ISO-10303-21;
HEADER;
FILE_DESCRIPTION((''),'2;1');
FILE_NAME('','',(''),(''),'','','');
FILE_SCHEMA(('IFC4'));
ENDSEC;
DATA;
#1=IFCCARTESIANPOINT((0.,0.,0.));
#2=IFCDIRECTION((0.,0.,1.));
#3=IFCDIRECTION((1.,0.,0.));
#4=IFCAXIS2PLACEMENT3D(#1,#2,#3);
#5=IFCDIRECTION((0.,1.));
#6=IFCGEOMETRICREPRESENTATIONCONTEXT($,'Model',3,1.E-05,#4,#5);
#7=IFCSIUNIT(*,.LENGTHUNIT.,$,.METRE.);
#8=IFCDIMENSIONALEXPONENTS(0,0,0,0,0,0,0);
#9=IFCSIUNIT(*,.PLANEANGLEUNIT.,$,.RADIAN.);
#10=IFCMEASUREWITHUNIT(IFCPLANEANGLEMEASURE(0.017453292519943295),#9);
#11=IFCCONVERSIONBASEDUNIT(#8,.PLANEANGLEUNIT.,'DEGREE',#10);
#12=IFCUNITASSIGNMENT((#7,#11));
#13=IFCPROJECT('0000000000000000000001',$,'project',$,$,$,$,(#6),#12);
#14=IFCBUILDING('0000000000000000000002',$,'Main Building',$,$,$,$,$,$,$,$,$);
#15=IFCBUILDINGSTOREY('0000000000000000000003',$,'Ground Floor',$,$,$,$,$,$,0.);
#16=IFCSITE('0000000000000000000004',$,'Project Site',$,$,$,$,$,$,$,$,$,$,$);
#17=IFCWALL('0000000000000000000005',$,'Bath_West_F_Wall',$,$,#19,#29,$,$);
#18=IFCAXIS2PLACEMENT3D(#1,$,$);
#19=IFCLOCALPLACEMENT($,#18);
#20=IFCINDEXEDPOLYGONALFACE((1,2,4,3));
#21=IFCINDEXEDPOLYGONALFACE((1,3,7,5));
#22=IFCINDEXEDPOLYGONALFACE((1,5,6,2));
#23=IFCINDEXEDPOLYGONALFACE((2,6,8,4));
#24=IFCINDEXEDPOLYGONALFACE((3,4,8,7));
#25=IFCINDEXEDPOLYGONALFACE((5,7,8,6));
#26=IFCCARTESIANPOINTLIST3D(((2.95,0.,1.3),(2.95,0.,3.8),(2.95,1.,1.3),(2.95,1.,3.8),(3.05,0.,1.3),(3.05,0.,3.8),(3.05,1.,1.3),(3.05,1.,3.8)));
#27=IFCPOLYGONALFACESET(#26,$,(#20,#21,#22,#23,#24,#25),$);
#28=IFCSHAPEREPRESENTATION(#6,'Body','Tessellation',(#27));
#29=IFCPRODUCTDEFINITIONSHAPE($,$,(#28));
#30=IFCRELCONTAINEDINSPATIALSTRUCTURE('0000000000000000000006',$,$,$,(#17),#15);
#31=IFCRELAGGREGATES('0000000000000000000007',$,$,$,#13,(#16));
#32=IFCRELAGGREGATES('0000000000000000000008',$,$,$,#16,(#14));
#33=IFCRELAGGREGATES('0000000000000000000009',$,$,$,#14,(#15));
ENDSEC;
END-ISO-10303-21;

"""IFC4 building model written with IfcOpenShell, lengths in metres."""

from ifc_helpers import new_model, entity, si_unit, converted_unit, direction, frame, frame_2d, origin, origin_with_axes, place, context, project, spatial, rectangle, extrude, element, save


model = new_model("IFC4")

# Units and contexts
model_context = context("Model", 3, precision=1e-05, world=origin_with_axes(), true_north=direction((0.0, 1.0)))
ifc_project = project(units=[si_unit("LENGTHUNIT", "METRE"), converted_unit("PLANEANGLEUNIT", "DEGREE", entity("IfcPlaneAngleMeasure", 0.017453292519943295), si_unit("PLANEANGLEUNIT", "RADIAN"), dimensions=[0, 0, 0, 0, 0, 0, 0])], contexts=[model_context])

# Site, building, storey
site = spatial("IfcSite", under=ifc_project, Name="Project Site")
building = spatial("IfcBuilding", under=site, Name="Main Building")
storey = spatial("IfcBuildingStorey", under=building, Name="Ground Floor", Elevation=0.0)

# Wall
wall_1_placement = place(None, frame((3.0, 0.0, 1.3), z_axis=(0.0, 0.0, 1.0), x_axis=(0.0, 1.0, 0.0)))
element("IfcWall", 1, at=wall_1_placement, inside=storey, Name="Bath_West_F_Wall", context=model_context, shape_type="SweptSolid", body=[
    extrude(rectangle(XDim=1.0, YDim=0.1, at=frame_2d((0.5, 0.0))), origin(), (0.0, 0.0, 1.0), 2.5),
])

save(model, "model.ifc")
